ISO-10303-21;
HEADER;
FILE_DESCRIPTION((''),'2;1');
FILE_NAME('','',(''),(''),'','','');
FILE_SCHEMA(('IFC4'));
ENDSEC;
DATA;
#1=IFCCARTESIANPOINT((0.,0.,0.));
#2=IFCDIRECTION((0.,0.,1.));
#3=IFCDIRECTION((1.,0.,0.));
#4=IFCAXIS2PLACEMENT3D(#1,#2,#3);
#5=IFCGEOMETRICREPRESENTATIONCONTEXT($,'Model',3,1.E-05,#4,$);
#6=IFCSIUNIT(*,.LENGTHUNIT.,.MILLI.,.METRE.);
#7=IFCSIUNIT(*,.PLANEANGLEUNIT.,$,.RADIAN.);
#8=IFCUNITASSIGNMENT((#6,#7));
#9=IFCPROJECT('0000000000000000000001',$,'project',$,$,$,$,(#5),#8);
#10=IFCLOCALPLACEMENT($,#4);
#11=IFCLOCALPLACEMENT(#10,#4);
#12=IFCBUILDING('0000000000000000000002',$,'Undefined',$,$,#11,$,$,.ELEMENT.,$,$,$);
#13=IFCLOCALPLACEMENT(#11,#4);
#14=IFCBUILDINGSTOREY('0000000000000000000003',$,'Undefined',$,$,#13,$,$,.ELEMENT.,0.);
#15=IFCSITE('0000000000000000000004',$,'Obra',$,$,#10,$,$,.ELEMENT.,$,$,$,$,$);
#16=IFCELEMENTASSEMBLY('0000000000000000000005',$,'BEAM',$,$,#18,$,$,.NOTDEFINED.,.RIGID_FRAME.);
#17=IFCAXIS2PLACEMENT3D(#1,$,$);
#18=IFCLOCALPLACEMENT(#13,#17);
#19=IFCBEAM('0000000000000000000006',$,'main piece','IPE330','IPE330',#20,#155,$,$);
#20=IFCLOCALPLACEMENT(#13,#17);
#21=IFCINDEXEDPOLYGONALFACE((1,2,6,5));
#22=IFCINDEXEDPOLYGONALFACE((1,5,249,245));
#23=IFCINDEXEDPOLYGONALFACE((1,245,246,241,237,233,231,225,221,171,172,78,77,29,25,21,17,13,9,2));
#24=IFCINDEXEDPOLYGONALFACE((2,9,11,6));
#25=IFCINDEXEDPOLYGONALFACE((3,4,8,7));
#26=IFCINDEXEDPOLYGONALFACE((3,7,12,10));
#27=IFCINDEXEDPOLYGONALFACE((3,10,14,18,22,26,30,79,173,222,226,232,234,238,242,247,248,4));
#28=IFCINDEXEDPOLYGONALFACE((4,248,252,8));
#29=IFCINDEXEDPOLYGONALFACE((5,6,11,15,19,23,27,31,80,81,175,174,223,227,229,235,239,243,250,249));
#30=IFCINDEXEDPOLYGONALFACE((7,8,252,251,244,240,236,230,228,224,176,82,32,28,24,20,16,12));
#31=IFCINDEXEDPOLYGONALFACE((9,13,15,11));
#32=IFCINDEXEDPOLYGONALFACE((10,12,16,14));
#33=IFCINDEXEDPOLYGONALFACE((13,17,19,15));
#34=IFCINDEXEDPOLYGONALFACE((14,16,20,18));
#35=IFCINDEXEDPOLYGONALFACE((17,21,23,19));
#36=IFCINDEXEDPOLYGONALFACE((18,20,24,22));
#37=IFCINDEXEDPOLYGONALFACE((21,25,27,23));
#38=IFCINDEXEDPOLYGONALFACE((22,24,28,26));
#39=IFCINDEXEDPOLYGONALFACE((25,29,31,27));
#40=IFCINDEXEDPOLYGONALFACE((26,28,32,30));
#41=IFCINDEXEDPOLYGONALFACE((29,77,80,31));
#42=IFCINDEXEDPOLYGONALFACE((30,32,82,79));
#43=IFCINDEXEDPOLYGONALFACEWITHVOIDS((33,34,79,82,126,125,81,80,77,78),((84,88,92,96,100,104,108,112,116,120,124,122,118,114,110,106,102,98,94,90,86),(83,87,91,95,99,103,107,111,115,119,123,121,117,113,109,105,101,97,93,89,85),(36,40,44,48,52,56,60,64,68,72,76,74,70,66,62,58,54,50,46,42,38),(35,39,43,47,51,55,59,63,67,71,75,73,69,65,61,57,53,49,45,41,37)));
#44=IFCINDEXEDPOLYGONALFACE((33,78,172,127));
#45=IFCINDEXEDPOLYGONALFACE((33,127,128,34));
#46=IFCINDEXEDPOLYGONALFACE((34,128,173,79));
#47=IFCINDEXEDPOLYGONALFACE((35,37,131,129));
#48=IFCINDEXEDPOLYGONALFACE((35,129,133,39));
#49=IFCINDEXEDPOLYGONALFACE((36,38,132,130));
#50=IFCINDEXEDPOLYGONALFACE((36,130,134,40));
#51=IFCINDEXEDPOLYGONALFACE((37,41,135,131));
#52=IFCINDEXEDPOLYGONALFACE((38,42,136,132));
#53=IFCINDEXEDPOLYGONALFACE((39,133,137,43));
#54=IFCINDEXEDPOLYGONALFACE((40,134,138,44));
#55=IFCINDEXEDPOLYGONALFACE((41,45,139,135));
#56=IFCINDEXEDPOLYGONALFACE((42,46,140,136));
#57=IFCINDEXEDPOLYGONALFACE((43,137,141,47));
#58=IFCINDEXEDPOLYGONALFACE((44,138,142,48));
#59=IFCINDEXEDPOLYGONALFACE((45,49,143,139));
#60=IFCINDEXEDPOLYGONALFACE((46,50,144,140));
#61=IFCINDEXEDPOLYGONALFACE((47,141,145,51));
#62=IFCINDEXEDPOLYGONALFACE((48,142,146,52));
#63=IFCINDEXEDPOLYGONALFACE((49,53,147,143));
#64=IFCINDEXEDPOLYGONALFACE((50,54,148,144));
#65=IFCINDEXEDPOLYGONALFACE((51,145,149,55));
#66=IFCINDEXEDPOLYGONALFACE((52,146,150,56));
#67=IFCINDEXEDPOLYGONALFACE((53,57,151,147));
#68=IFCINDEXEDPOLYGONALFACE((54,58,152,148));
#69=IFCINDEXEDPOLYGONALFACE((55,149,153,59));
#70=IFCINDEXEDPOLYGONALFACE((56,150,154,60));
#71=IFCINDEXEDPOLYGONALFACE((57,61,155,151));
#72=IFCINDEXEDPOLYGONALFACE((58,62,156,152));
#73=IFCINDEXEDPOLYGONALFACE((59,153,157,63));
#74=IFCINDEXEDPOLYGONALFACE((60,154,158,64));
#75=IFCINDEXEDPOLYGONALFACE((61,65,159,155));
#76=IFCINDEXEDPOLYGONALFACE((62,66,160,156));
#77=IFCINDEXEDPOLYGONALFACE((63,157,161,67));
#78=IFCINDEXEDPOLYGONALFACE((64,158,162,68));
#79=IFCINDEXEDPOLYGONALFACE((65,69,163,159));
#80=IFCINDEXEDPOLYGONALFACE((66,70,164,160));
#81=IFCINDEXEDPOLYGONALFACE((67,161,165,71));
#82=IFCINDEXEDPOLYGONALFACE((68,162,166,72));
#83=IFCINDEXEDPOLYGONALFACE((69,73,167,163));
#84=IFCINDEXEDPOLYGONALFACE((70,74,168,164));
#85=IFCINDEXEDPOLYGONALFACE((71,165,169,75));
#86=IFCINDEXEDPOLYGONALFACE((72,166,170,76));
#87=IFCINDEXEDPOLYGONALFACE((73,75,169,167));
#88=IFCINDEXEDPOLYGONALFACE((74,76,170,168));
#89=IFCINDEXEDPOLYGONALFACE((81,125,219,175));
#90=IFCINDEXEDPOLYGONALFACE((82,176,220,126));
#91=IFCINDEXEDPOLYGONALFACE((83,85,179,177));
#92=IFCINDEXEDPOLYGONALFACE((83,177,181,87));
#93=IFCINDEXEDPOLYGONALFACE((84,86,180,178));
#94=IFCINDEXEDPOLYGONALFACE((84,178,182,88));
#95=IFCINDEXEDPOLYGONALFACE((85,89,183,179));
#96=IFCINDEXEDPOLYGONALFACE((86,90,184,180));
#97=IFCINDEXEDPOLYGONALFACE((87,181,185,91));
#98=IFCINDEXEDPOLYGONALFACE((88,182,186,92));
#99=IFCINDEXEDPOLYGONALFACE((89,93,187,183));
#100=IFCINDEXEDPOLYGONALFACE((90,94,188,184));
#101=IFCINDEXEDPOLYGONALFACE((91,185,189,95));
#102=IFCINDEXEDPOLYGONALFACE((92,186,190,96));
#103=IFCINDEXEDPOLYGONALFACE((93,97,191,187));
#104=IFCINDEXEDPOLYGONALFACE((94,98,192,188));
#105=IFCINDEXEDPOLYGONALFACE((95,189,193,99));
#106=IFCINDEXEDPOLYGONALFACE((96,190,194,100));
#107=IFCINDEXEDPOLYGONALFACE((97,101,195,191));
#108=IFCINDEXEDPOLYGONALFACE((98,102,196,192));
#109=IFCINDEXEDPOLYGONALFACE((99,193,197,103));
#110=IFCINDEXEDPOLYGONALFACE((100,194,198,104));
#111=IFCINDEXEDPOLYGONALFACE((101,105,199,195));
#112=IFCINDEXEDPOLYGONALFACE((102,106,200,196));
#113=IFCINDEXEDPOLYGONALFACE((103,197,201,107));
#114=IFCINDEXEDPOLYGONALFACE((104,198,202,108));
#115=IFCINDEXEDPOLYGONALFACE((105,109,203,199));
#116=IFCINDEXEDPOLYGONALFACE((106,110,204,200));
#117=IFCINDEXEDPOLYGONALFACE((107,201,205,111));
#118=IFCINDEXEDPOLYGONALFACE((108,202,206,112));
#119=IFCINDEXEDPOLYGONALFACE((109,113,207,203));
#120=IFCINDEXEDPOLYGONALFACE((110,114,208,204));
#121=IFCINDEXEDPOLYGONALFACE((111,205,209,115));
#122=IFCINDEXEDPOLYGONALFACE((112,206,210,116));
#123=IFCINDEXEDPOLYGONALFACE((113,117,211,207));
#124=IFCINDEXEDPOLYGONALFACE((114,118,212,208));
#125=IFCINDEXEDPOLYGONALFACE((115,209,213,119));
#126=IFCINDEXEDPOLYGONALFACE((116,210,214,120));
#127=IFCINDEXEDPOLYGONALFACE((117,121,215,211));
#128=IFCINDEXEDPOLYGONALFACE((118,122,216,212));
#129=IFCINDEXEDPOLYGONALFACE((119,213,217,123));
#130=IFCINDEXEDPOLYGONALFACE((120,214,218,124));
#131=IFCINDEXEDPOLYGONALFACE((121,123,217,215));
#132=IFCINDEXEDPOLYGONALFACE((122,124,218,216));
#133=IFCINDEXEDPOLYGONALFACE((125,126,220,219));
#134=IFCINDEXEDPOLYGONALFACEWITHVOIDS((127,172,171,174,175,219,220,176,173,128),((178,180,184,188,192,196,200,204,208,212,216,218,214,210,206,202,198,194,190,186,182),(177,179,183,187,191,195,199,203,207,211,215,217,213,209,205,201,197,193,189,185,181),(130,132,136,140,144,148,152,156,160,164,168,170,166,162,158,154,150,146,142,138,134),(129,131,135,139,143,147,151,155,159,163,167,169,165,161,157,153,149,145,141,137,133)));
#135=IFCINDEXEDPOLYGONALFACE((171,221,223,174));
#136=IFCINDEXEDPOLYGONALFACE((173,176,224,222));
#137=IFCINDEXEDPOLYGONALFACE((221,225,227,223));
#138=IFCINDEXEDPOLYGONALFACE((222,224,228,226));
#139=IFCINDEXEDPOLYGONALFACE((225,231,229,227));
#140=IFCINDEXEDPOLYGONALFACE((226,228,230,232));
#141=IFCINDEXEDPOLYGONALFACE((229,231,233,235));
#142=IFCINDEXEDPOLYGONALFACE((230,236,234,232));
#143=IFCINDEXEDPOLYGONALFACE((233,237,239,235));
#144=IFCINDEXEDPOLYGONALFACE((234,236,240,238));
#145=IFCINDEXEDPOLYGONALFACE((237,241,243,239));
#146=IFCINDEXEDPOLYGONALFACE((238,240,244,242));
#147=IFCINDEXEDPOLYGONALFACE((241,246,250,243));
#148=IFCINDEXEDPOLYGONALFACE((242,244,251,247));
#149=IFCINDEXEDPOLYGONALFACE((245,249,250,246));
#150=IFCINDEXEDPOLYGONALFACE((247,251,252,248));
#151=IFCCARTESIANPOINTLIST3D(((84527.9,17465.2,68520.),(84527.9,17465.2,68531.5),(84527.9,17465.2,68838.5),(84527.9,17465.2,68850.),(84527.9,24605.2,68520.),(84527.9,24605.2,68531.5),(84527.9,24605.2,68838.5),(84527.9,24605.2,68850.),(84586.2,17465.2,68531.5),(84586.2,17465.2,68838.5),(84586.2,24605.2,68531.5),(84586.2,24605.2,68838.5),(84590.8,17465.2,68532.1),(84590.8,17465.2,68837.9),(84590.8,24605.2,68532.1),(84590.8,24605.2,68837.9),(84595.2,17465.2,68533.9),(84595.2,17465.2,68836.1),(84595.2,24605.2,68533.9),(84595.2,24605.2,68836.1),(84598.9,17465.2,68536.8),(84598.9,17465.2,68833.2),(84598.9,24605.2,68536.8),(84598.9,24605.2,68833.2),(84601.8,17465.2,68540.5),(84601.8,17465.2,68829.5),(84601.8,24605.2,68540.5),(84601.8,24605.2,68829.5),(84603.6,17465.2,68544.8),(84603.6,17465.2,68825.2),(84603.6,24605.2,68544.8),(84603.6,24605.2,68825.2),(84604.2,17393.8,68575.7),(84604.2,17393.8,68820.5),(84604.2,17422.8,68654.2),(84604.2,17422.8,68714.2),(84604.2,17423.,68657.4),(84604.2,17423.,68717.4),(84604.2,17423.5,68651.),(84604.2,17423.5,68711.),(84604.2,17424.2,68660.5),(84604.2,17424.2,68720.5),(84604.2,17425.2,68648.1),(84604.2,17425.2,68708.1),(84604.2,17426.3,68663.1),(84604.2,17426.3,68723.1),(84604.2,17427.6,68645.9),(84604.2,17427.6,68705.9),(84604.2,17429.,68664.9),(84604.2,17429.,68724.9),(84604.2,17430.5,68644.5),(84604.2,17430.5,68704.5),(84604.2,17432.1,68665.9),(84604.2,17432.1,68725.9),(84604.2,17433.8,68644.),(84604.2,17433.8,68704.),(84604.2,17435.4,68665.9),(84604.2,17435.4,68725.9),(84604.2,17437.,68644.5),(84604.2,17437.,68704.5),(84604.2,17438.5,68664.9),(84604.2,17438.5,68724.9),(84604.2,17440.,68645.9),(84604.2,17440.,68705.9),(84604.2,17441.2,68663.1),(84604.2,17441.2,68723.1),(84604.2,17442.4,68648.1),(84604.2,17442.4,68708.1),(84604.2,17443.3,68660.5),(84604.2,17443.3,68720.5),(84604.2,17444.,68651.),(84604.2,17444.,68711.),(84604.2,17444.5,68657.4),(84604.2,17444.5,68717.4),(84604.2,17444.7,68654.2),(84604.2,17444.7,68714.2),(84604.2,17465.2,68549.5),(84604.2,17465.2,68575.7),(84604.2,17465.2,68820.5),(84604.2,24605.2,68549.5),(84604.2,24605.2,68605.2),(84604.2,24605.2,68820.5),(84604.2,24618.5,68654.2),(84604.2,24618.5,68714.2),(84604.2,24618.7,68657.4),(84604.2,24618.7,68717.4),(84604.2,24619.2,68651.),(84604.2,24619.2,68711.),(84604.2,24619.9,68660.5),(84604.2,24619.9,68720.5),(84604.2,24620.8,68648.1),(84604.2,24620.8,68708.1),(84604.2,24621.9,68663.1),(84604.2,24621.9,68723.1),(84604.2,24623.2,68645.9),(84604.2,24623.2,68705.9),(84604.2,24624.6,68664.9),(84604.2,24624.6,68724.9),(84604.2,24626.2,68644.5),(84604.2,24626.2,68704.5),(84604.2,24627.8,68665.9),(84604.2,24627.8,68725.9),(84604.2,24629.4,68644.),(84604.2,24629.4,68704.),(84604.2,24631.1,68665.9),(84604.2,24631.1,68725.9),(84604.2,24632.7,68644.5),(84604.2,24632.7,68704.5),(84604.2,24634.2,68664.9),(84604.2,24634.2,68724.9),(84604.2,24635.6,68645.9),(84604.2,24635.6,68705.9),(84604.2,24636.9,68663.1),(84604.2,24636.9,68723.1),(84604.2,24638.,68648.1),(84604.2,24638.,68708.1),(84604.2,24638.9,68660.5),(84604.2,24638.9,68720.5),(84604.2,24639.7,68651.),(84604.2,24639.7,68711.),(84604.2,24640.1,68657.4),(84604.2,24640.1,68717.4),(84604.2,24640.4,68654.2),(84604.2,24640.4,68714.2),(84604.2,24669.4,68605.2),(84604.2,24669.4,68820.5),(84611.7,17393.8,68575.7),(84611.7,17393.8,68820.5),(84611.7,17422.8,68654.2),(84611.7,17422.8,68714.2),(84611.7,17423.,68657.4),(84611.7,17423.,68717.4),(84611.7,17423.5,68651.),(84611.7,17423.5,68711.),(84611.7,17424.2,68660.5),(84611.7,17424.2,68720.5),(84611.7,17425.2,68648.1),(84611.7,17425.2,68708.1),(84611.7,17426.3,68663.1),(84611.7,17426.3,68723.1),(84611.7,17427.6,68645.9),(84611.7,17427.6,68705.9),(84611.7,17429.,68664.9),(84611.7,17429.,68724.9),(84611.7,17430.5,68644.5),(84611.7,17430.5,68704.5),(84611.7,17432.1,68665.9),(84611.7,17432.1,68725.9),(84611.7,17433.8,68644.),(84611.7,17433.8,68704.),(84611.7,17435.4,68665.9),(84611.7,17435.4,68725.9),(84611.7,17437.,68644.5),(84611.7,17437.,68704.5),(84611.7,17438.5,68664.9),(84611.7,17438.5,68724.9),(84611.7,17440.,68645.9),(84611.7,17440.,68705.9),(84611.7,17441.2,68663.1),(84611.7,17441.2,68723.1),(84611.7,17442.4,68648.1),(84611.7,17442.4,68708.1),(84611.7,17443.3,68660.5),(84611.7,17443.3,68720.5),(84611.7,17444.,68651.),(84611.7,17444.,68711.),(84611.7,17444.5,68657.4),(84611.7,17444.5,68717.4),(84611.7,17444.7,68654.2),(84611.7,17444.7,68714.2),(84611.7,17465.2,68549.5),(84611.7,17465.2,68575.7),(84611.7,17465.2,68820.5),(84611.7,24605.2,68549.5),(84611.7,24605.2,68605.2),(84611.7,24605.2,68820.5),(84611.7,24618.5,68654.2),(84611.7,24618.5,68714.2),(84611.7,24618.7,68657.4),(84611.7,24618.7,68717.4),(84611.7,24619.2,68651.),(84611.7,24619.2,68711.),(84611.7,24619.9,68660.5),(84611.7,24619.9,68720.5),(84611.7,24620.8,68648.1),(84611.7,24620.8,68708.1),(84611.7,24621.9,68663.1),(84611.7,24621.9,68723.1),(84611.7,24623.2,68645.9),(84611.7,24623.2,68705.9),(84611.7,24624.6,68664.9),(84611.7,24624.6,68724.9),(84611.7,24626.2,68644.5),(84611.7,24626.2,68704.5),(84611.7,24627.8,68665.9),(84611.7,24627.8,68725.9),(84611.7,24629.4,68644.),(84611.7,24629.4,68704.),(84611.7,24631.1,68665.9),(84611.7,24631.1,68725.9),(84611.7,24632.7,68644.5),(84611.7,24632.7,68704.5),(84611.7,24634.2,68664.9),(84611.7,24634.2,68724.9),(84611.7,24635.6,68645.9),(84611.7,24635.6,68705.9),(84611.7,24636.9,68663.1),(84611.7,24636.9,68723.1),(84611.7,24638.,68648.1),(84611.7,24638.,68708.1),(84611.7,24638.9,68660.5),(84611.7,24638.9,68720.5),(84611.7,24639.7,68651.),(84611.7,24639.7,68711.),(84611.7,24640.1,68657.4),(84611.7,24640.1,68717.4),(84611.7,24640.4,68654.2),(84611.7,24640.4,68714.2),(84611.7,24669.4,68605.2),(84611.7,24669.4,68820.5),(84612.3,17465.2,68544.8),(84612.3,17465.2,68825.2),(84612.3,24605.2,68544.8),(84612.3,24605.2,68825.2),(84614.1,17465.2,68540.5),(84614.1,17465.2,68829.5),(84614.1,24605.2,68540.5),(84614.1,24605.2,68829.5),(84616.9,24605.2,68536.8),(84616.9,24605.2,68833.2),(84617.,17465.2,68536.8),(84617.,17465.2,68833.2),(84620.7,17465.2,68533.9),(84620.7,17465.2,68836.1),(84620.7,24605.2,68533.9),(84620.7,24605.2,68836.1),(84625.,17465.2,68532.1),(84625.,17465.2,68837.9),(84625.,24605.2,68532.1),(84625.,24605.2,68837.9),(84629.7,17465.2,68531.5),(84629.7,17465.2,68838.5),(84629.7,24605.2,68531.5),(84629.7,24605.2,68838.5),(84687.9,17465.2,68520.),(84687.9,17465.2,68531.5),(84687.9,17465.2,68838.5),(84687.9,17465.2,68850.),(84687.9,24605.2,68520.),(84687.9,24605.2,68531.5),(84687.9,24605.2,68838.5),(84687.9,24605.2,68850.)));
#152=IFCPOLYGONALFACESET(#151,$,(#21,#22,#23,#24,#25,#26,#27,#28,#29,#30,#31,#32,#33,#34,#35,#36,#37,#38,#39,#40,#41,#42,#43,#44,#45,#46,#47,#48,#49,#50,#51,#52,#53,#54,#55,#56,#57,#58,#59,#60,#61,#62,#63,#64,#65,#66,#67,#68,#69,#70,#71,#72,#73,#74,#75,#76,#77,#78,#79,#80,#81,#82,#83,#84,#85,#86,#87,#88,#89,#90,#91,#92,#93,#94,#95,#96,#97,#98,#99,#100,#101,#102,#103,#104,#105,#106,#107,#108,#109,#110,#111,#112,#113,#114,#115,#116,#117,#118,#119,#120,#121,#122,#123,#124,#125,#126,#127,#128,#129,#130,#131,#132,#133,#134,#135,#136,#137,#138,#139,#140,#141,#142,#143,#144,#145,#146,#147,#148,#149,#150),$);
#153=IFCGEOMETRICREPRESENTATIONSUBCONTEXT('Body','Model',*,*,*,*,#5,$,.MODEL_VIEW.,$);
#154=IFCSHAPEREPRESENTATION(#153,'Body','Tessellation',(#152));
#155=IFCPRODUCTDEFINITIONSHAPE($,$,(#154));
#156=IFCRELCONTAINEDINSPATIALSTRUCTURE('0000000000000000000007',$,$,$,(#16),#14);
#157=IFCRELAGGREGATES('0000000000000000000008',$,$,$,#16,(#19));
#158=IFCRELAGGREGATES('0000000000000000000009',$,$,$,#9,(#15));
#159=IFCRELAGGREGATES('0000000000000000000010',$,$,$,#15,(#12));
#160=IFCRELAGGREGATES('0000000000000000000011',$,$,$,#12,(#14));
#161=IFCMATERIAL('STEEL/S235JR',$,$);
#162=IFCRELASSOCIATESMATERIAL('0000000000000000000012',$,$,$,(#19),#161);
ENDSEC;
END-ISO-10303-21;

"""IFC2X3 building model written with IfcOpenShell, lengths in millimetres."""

from ifc_helpers import new_model, si_unit, frame, origin_with_axes, origin_2d_with_axis, place, context, subcontext, project, spatial, rectangle, circle, i_section, extrude, clip, halfspace, source, transform, mapped, material, element, aggregate, save


model = new_model("IFC2X3")

# Units and contexts
model_context = context("Model", 3, precision=1e-05, world=origin_with_axes())
body_context = subcontext(model_context, "Body", "Model", "MODEL_VIEW")
ifc_project = project(units=[si_unit("LENGTHUNIT", "METRE", prefix="MILLI"), si_unit("PLANEANGLEUNIT", "RADIAN")], contexts=[model_context])

# Site, building, storey
site_placement = place(None, origin_with_axes())
site = spatial("IfcSite", under=ifc_project, at=site_placement, Name="Obra", CompositionType="ELEMENT")
building_placement = place(site_placement, origin_with_axes())
building = spatial("IfcBuilding", under=site, at=building_placement, Name="Undefined", CompositionType="ELEMENT")
storey_placement = place(building_placement, origin_with_axes())
storey = spatial("IfcBuildingStorey", under=building, at=storey_placement, Name="Undefined", CompositionType="ELEMENT", Elevation=0.0)

# Shared definitions
ifc_material = material(Name="STEEL/S235JR")

# Element assembly, beam, openings
assembly_1_placement = place(storey_placement, origin_with_axes())
assembly_1 = element("IfcElementAssembly", 1, at=assembly_1_placement, inside=storey, Name="BEAM", AssemblyPlace="NOTDEFINED", PredefinedType="RIGID_FRAME")
beam_1_placement = place(assembly_1_placement, frame((84607.9, 17475.2, 68685.0), z_axis=(0.0, 0.0, 1.0), x_axis=(-0.000002, 1.0, 0.0)))
beam_1 = element("IfcBeam", 2, at=beam_1_placement, material=ifc_material, Name="main piece", Description="IPE330", ObjectType="IPE330", context=body_context, shape_type="Clipping", body=[
    clip(clip(extrude(i_section(OverallWidth=160.0, OverallDepth=330.0, WebThickness=7.5, FlangeThickness=11.5, FilletRadius=18.0, at=origin_2d_with_axis()), frame((7194.2, 0.0, 0.0), z_axis=(-1.0, 0.0, 0.0), x_axis=(0.0, -1.0, 0.0)), (0.0, 0.0, 1.0), 7275.7), halfspace(frame((7194.2, 0.0, -265.0), z_axis=(-1.0, 0.0, 0.0), x_axis=(0.0, 1.0, 0.0)), True)), halfspace(frame((-81.5, 0.0, -265.0), z_axis=(1.0, -0.000001, 0.0), x_axis=(-0.000001, -1.0, 0.0)), True)),
])
opening_1_placement = place(assembly_1_placement, frame((84607.9, 17475.2, 68685.0), z_axis=(0.0, 0.0, 1.0), x_axis=(-0.000002, 1.0, 0.0)))
element("IfcOpeningElement", 3, at=opening_1_placement, cuts=beam_1, ObjectType="Recess", context=body_context, shape_type="SweptSolid", body=[
    extrude(rectangle(XDim=76.2, YDim=86.2, at=origin_2d_with_axis()), frame((7168.1, 81.0, -122.9), z_axis=(0.0, -1.0, 0.0), x_axis=(1.0, 0.0, 0.0)), (0.0, 0.0, 1.0), 162.0),
])
opening_2_placement = place(assembly_1_placement, frame((84607.9, 17475.2, 68685.0), z_axis=(0.0, 0.0, 1.0), x_axis=(-0.000002, 1.0, 0.0)))
element("IfcOpeningElement", 4, at=opening_2_placement, cuts=beam_1, ObjectType="Recess", context=body_context, shape_type="SweptSolid", body=[
    extrude(rectangle(XDim=30.5, YDim=76.2, at=origin_2d_with_axis()), frame((7168.1, 81.0, 150.8), z_axis=(0.0, -1.0, 0.0), x_axis=(0.0, 0.0, -1.0)), (0.0, 0.0, 1.0), 162.0),
])
opening_3_placement = place(assembly_1_placement, frame((84607.9, 17475.2, 68685.0), z_axis=(0.0, 0.0, 1.0), x_axis=(-0.000002, 1.0, 0.0)))
element("IfcOpeningElement", 5, at=opening_3_placement, cuts=beam_1, ObjectType="Recess", context=body_context, shape_type="SweptSolid", body=[
    extrude(rectangle(XDim=56.7, YDim=83.5, at=origin_2d_with_axis()), frame((-51.7, -81.0, -137.7), z_axis=(0.000002, 1.0, 0.0), x_axis=(0.0, 0.0, -1.0)), (0.0, 0.0, 1.0), 162.0),
])
opening_4_placement = place(assembly_1_placement, frame((84607.9, 17475.2, 68685.0), z_axis=(0.0, 0.0, 1.0), x_axis=(-0.000002, 1.0, 0.0)))
element("IfcOpeningElement", 6, at=opening_4_placement, cuts=beam_1, ObjectType="Recess", context=body_context, shape_type="SweptSolid", body=[
    extrude(rectangle(XDim=30.5, YDim=83.5, at=origin_2d_with_axis()), frame((-51.7, -81.0, 150.8), z_axis=(0.000002, 1.0, 0.0), x_axis=(0.0, 0.0, -1.0)), (0.0, 0.0, 1.0), 162.0),
])
shared_shape_1 = source(origin_with_axes(), body_context, "Body", "SweptSolid", [
    extrude(circle(Radius=11.0, at=origin_2d_with_axis()), frame((0.0, -3.9, 0.0), z_axis=(0.0, 1.0, 0.0), x_axis=(1.0, 0.0, 0.0)), (0.0, 0.0, 1.0), 7.7),
])
opening_5_placement = place(assembly_1_placement, frame((84607.9, 24669.4, 68850.0), z_axis=(0.000002, -1.0, 0.0), x_axis=(0.0, 0.0, -1.0)))
element("IfcOpeningElement", 7, at=opening_5_placement, cuts=beam_1, ObjectType="Opening", context=body_context, shape_type="MappedRepresentation", body=[
    mapped(shared_shape_1, transform((135.0, 0.0, 40.0))),
    mapped(shared_shape_1, transform((195.0, 0.0, 40.0))),
])
opening_6_placement = place(assembly_1_placement, frame((84607.9, 17393.8, 68850.0), z_axis=(0.0, 1.0, 0.0), x_axis=(0.0, 0.0, -1.0)))
element("IfcOpeningElement", 8, at=opening_6_placement, cuts=beam_1, ObjectType="Opening", context=body_context, shape_type="MappedRepresentation", body=[
    mapped(shared_shape_1, transform((135.0, 0.0, 40.0))),
    mapped(shared_shape_1, transform((195.0, 0.0, 40.0))),
])
aggregate(assembly_1, [beam_1])

save(model, "model.ifc")
